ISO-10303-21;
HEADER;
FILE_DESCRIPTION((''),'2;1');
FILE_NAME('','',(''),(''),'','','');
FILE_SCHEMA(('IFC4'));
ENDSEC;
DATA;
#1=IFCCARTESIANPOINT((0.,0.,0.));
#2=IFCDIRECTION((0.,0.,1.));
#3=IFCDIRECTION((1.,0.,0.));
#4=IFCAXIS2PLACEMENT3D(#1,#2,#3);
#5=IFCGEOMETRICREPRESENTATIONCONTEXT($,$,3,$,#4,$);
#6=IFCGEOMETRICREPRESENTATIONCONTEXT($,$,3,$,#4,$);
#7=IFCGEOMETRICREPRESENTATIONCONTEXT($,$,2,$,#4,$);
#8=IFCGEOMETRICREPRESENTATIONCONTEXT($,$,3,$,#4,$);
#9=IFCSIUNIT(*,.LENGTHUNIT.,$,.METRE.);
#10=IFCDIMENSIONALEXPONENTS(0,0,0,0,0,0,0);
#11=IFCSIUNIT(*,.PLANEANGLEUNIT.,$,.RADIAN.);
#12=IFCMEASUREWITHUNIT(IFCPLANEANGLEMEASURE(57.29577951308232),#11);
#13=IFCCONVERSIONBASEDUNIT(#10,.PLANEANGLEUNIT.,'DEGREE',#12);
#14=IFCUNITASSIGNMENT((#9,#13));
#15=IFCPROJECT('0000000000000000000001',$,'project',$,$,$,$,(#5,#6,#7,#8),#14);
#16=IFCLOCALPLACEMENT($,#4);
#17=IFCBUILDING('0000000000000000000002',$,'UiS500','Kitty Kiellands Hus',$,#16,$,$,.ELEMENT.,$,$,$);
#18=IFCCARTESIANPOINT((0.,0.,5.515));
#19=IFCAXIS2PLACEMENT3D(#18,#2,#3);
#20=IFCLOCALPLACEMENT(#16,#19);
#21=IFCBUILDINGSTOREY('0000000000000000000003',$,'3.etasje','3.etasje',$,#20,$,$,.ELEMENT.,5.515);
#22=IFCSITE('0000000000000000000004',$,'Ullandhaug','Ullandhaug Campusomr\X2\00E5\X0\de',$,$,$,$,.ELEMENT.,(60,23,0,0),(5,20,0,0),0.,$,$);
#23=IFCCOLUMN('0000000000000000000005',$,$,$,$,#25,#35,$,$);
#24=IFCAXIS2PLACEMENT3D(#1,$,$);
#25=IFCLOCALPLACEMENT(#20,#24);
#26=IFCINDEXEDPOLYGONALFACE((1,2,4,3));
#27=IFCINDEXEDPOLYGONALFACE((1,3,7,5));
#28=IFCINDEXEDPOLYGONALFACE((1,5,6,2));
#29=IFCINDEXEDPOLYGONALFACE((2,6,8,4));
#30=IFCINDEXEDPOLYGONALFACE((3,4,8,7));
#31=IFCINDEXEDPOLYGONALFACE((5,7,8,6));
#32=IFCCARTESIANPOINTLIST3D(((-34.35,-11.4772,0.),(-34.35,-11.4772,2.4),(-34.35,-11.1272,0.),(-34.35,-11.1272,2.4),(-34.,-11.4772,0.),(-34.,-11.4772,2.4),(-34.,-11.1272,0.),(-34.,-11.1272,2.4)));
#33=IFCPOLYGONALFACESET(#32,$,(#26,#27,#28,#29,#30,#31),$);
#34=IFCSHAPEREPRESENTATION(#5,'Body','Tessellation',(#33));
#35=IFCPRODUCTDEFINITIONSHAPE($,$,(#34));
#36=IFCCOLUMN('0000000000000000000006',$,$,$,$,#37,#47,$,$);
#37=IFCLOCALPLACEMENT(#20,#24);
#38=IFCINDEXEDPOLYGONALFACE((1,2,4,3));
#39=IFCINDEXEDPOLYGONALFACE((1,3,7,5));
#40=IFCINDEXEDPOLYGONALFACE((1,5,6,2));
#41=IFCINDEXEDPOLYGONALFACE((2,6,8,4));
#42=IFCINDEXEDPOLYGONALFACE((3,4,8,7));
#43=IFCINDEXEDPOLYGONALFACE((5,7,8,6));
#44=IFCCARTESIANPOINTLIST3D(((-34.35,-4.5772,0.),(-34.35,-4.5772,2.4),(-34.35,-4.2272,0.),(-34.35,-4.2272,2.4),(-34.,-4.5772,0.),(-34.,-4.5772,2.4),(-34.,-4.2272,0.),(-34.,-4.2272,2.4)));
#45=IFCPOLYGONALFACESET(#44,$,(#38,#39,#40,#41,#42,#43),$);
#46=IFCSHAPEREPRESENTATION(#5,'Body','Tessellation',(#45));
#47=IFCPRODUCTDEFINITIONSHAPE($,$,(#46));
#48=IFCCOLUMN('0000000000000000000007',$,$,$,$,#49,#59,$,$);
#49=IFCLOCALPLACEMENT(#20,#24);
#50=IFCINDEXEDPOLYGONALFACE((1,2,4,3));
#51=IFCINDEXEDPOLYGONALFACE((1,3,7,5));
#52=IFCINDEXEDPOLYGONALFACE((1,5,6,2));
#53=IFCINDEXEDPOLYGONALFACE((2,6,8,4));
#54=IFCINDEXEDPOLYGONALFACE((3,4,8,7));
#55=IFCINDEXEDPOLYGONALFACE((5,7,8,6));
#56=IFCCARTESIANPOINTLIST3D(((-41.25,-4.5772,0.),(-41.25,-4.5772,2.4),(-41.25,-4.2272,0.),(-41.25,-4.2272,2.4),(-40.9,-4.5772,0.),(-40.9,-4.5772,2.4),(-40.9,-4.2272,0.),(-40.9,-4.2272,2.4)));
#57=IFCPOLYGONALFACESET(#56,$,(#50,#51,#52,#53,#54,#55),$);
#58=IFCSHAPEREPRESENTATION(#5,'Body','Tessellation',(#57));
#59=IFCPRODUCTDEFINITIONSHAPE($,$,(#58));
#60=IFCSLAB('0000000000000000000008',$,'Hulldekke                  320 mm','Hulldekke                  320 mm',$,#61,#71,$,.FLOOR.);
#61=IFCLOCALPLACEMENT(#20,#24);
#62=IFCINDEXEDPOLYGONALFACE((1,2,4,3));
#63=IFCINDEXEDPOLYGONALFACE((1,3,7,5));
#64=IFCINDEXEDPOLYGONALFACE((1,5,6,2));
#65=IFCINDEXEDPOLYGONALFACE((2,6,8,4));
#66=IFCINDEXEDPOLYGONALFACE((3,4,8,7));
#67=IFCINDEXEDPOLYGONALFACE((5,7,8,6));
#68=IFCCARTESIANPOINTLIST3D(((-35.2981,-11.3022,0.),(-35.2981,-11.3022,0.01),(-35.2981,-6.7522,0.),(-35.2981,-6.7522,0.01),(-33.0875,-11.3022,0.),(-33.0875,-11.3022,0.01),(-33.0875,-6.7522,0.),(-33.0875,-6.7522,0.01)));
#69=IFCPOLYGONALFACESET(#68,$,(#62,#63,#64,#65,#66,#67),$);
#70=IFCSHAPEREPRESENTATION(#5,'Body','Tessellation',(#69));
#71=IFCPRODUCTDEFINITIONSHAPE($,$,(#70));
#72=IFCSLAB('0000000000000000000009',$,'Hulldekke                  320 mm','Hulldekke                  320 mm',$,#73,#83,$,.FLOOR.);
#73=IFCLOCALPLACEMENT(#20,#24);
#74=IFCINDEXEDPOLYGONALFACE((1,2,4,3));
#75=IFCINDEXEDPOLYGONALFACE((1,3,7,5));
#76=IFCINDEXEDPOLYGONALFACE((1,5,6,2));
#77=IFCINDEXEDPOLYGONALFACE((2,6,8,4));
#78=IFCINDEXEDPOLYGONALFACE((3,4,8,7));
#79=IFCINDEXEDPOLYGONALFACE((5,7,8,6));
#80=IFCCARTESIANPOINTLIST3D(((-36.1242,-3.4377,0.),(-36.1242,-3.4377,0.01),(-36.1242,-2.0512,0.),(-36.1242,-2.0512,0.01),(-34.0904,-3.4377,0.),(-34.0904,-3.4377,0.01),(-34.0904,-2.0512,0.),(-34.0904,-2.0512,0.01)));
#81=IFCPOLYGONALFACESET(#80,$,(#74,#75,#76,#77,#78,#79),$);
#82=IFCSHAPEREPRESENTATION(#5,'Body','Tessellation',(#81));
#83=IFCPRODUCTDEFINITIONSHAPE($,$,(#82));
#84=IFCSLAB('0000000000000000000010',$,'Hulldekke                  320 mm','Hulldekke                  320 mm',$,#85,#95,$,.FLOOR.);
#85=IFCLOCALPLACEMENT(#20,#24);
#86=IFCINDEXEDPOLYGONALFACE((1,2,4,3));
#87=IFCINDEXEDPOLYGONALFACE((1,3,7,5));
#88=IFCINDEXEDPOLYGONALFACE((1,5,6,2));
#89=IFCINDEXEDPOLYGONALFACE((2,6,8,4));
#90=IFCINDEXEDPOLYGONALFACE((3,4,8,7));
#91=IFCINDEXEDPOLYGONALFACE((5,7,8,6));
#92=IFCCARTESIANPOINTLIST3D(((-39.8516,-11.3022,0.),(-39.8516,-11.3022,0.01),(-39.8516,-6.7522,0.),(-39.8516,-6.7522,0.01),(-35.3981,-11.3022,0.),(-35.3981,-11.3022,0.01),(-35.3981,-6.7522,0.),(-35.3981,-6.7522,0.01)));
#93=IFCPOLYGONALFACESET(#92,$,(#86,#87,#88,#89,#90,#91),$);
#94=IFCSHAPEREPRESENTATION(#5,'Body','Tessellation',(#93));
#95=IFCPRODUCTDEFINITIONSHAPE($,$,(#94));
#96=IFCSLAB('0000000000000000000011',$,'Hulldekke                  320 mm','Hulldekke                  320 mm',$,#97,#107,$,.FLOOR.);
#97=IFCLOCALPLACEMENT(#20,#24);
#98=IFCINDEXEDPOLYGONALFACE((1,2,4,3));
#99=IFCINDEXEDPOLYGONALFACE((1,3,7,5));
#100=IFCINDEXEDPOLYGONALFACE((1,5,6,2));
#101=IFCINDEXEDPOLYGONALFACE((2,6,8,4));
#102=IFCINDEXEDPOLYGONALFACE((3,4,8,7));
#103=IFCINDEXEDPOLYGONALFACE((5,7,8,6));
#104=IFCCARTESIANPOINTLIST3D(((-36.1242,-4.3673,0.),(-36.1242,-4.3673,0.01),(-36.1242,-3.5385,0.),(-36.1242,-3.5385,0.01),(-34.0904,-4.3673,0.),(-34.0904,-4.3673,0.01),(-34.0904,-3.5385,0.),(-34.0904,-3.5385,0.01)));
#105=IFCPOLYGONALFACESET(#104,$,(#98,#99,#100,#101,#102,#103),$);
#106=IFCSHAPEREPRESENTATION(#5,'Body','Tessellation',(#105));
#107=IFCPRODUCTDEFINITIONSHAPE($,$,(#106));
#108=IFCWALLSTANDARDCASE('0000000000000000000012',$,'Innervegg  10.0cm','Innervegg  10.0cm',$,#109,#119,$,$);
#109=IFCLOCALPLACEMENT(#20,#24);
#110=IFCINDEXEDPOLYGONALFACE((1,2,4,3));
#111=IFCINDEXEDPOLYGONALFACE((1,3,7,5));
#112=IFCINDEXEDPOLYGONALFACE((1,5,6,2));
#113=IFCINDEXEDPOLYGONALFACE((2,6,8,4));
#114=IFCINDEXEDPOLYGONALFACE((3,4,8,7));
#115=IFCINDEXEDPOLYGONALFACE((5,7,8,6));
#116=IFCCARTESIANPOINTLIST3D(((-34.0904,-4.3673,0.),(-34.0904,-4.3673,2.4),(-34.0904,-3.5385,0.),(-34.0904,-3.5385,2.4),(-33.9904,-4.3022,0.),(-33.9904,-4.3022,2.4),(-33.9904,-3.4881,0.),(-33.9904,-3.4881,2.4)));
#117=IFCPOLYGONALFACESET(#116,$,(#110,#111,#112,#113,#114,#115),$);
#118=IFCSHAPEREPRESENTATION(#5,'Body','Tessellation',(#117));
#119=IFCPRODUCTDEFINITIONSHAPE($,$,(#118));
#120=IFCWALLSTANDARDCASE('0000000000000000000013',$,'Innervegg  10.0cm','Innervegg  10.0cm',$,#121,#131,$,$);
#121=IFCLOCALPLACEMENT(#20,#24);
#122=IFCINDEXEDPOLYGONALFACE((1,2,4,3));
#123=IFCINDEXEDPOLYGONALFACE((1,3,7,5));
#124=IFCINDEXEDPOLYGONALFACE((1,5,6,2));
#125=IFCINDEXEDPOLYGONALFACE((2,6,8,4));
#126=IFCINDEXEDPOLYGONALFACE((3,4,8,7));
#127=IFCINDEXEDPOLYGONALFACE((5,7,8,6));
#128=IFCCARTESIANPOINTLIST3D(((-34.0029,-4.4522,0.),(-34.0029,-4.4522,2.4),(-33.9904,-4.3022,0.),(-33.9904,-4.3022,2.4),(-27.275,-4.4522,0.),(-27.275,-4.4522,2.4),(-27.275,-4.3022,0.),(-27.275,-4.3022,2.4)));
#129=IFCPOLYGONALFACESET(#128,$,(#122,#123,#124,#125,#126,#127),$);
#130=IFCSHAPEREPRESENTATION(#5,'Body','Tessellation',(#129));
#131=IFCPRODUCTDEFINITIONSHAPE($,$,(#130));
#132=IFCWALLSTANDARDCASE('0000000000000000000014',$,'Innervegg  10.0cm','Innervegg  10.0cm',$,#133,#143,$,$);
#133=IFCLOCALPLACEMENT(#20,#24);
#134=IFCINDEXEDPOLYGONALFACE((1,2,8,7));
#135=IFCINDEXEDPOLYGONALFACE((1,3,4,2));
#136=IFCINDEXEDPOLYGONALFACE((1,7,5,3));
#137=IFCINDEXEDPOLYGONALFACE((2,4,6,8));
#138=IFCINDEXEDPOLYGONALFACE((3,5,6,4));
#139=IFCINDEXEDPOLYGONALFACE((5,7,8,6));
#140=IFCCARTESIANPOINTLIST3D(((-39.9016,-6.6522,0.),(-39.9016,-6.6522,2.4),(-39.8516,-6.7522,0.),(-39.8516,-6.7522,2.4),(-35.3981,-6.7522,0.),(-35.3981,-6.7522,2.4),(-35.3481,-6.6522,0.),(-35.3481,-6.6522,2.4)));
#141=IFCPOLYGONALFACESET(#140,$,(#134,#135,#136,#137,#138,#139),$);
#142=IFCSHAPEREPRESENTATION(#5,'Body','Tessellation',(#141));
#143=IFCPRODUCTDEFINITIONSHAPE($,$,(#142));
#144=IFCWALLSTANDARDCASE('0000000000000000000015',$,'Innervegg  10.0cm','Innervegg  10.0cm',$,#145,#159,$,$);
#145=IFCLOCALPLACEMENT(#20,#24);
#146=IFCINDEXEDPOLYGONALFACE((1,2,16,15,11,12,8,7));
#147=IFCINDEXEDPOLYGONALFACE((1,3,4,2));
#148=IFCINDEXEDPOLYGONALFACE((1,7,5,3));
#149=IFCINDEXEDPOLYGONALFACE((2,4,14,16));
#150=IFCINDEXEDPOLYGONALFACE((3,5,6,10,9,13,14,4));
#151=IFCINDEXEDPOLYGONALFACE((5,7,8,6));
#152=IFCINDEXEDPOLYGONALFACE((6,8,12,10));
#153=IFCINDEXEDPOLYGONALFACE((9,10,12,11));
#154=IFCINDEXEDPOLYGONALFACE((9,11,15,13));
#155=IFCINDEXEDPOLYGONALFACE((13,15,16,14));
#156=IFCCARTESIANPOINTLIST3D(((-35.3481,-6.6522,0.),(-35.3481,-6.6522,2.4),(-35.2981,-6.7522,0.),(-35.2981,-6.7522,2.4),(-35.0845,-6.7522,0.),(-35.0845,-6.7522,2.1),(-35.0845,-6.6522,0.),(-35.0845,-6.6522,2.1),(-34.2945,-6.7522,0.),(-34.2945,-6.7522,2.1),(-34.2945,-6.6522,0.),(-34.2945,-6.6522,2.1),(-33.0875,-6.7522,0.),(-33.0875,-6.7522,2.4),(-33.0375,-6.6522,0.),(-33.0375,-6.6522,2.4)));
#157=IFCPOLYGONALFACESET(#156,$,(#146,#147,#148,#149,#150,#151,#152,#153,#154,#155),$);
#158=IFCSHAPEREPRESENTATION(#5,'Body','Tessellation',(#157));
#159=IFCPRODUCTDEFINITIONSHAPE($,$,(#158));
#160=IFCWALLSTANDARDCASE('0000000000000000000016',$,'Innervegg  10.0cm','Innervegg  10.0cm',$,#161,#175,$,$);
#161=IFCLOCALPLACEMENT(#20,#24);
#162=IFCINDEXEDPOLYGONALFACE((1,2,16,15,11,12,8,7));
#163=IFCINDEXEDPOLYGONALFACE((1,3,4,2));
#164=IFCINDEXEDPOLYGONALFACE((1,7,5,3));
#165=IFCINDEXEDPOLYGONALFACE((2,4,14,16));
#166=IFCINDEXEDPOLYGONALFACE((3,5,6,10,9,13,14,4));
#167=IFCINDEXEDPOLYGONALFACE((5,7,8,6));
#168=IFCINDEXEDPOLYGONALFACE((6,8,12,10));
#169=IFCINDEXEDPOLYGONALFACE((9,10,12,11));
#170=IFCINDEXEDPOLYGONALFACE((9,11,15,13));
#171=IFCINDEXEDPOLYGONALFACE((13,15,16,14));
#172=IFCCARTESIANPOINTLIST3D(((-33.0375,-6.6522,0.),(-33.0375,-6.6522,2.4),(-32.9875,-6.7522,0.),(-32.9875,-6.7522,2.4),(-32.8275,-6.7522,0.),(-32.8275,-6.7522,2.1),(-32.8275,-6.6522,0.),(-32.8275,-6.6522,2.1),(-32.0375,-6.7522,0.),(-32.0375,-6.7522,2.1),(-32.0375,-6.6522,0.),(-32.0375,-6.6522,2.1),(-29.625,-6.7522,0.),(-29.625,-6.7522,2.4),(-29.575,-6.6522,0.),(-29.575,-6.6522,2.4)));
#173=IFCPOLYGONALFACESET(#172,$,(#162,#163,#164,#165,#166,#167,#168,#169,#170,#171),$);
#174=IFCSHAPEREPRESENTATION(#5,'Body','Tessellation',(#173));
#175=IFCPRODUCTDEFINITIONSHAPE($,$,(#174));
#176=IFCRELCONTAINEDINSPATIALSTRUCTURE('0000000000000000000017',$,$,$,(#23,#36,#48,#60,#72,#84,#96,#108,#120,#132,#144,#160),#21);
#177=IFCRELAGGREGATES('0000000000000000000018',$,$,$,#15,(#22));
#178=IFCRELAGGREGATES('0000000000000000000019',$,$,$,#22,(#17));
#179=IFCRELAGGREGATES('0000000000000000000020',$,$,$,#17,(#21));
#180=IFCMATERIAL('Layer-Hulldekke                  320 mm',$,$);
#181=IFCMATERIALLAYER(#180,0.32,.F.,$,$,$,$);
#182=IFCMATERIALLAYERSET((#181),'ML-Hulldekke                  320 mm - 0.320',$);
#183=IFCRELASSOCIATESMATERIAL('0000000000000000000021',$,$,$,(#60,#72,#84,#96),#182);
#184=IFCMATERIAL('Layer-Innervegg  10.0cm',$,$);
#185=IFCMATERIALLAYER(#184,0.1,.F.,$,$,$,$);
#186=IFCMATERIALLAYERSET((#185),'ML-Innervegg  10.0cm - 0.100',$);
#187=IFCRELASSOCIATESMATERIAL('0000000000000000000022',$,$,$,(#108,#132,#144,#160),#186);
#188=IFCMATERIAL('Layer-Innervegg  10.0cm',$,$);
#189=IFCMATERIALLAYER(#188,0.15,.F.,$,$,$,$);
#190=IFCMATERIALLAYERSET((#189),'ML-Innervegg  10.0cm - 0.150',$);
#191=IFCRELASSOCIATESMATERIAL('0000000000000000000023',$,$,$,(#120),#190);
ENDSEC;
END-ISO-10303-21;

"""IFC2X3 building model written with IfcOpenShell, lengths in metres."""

from ifc_helpers import new_model, entity, si_unit, converted_unit, frame, origin_with_axes, origin_2d_with_axis, place, context, project, spatial, polyline, rectangle, outline, extrude, material, layer, layer_set, layer_usage, element, save


model = new_model("IFC2X3")

# Units and contexts
context_of_model_1 = context(None, 3, world=origin_with_axes())
context_of_model_2 = context(None, 3, world=origin_with_axes())
context_of_model_3 = context(None, 2, world=origin_with_axes())
context_of_model_4 = context(None, 3, world=origin_with_axes())
ifc_project = project(units=[si_unit("LENGTHUNIT", "METRE"), converted_unit("PLANEANGLEUNIT", "DEGREE", entity("IfcPlaneAngleMeasure", 57.29577951308232), si_unit("PLANEANGLEUNIT", "RADIAN"), dimensions=[0, 0, 0, 0, 0, 0, 0])], contexts=[context_of_model_1, context_of_model_2, context_of_model_3, context_of_model_4])

# Site, building, storey
site = spatial("IfcSite", under=ifc_project, Name="Ullandhaug", Description="Ullandhaug Campusområde", CompositionType="ELEMENT", RefLatitude=(60, 23, 0, 0), RefLongitude=(5, 20, 0, 0), RefElevation=0.0)
building_placement = place(None, origin_with_axes())
building = spatial("IfcBuilding", under=site, at=building_placement, Name="UiS500", Description="Kitty Kiellands Hus", CompositionType="ELEMENT")
storey_placement = place(building_placement, frame((0.0, 0.0, 5.515), z_axis=(0.0, 0.0, 1.0), x_axis=(1.0, 0.0, 0.0)))
storey = spatial("IfcBuildingStorey", under=building, at=storey_placement, Name="3.etasje", Description="3.etasje", CompositionType="ELEMENT", Elevation=5.515)

# Columns
for number, where, z_axis, x_axis in (
    (1, (-34.175, -11.3022, 0.0), (0.0, 0.0, 1.0), (1.0, 0.0, 0.0)),
    (2, (-34.175, -4.4022, 0.0), (0.0, 0.0, 1.0), (1.0, 0.0, 0.0)),
    (3, (-41.075, -4.4022, 0.0), (0.0, 0.0, 1.0), (1.0, 0.0, 0.0)),
):
    element("IfcColumn", number, at=place(storey_placement, frame(where, z_axis=z_axis, x_axis=x_axis)), inside=storey, context=context_of_model_1, shape_type="SweptSolid", body=[
        extrude(rectangle(XDim=0.35, YDim=0.35, at=origin_2d_with_axis()), origin_with_axes(), (0.0, 0.0, 1.0), 2.4),
    ])

# Slabs
ifc_material_1 = material(Name="Layer-Hulldekke                  320 mm")
ifc_layer_1 = layer(ifc_material_1, 0.32, ventilated=False)
ifc_layer_set_1 = layer_set([ifc_layer_1], Name="ML-Hulldekke                  320 mm - 0.320")
ifc_layer_usage_1 = layer_usage(ifc_layer_set_1, "AXIS2", "POSITIVE", 0.0)
slab_1_placement = place(storey_placement, frame((-35.2981, -11.3022, 0.0), z_axis=(0.0, 0.0, 1.0), x_axis=(1.0, 0.0, 0.0)))
element("IfcSlab", 4, at=slab_1_placement, inside=storey, material=ifc_layer_usage_1, Name="Hulldekke                  320 mm", Description="Hulldekke                  320 mm", PredefinedType="FLOOR", context=context_of_model_1, shape_type="SweptSolid", body=[
    extrude(outline(polyline([(0.0, 0.0), (2.2106, 0.0), (2.2106, 4.55), (0.0, 4.55), (0.0, 0.0)])), origin_with_axes(), (0.0, 0.0, 1.0), 0.01),
])
slab_2_placement = place(storey_placement, frame((-36.1242, -3.4377, 0.0), z_axis=(0.0, 0.0, 1.0), x_axis=(1.0, 0.0, 0.0)))
element("IfcSlab", 5, at=slab_2_placement, inside=storey, material=ifc_layer_usage_1, Name="Hulldekke                  320 mm", Description="Hulldekke                  320 mm", PredefinedType="FLOOR", context=context_of_model_1, shape_type="SweptSolid", body=[
    extrude(outline(polyline([(0.0, 0.0), (2.0338, 0.0), (2.0338, 1.3864), (0.0, 1.3864), (0.0, 0.0)])), origin_with_axes(), (0.0, 0.0, 1.0), 0.01),
])
slab_3_placement = place(storey_placement, frame((-39.8516, -6.7522, 0.0), z_axis=(0.0, 0.0, 1.0), x_axis=(1.0, 0.0, 0.0)))
element("IfcSlab", 6, at=slab_3_placement, inside=storey, material=ifc_layer_usage_1, Name="Hulldekke                  320 mm", Description="Hulldekke                  320 mm", PredefinedType="FLOOR", context=context_of_model_1, shape_type="SweptSolid", body=[
    extrude(outline(polyline([(0.0, 0.0), (4.55, 0.0), (4.55, 4.4535), (0.0, 4.4535), (0.0, 0.0)])), frame((0.0, 0.0, 0.0), z_axis=(0.0, 0.0, 1.0), x_axis=(0.0, -1.0, 0.0)), (0.0, 0.0, 1.0), 0.01),
])
slab_4_placement = place(storey_placement, frame((-36.1242, -4.3673, 0.0), z_axis=(0.0, 0.0, 1.0), x_axis=(1.0, 0.0, 0.0)))
element("IfcSlab", 7, at=slab_4_placement, inside=storey, material=ifc_layer_usage_1, Name="Hulldekke                  320 mm", Description="Hulldekke                  320 mm", PredefinedType="FLOOR", context=context_of_model_1, shape_type="SweptSolid", body=[
    extrude(outline(polyline([(0.0, 0.0), (2.0338, 0.0), (2.0338, 0.8288), (0.0, 0.8288), (0.0, 0.0)])), origin_with_axes(), (0.0, 0.0, 1.0), 0.01),
])

# Walls
ifc_material_2 = material(Name="Layer-Innervegg  10.0cm")
ifc_layer_2 = layer(ifc_material_2, 0.1, ventilated=False)
ifc_layer_set_2 = layer_set([ifc_layer_2], Name="ML-Innervegg  10.0cm - 0.100")
ifc_layer_usage_2 = layer_usage(ifc_layer_set_2, "AXIS2", "POSITIVE", 0.0)
wall_1_placement = place(storey_placement, frame((-34.0904, -3.5385, 0.0), z_axis=(0.0, 0.0, 1.0), x_axis=(0.0, -1.0, 0.0)))
element("IfcWallStandardCase", 8, at=wall_1_placement, inside=storey, material=ifc_layer_usage_2, Name="Innervegg  10.0cm", Description="Innervegg  10.0cm", context=context_of_model_1, shape_type="SweptSolid", body=[
    extrude(outline(polyline([(0.0, 0.0), (0.8288, 0.0), (0.7638, 0.1), (-0.0504, 0.1), (0.0, 0.0)])), frame((0.0, 0.0, 0.0), z_axis=(0.0, 0.0, 1.0), x_axis=(1.0, 0.0, 0.0)), (0.0, 0.0, 1.0), 2.4),
])
ifc_material_3 = material(Name="Layer-Innervegg  10.0cm")
ifc_layer_3 = layer(ifc_material_3, 0.15, ventilated=False)
ifc_layer_set_3 = layer_set([ifc_layer_3], Name="ML-Innervegg  10.0cm - 0.150")
ifc_layer_usage_3 = layer_usage(ifc_layer_set_3, "AXIS2", "POSITIVE", 0.0)
wall_2_placement = place(storey_placement, frame((-34.0029, -4.4522, 0.0), z_axis=(0.0, 0.0, 1.0), x_axis=(1.0, 0.0, 0.0)))
element("IfcWallStandardCase", 9, at=wall_2_placement, inside=storey, material=ifc_layer_usage_3, Name="Innervegg  10.0cm", Description="Innervegg  10.0cm", context=context_of_model_1, shape_type="SweptSolid", body=[
    extrude(outline(polyline([(0.0, 0.0), (6.7279, 0.0), (6.7279, 0.15), (0.0125, 0.15), (0.0, 0.0)])), origin_with_axes(), (0.0, 0.0, 1.0), 2.4),
])
wall_3_placement = place(storey_placement, frame((-39.8516, -6.7522, 0.0), z_axis=(0.0, 0.0, 1.0), x_axis=(1.0, 0.0, 0.0)))
element("IfcWallStandardCase", 10, at=wall_3_placement, inside=storey, material=ifc_layer_usage_2, Name="Innervegg  10.0cm", Description="Innervegg  10.0cm", context=context_of_model_1, shape_type="SweptSolid", body=[
    extrude(outline(polyline([(0.0, 0.0), (4.4535, 0.0), (4.5035, 0.1), (-0.05, 0.1), (0.0, 0.0)])), origin_with_axes(), (0.0, 0.0, 1.0), 2.4),
])

# Walls, openings
wall_4_placement = place(storey_placement, frame((-35.2981, -6.7522, 0.0), z_axis=(0.0, 0.0, 1.0), x_axis=(1.0, 0.0, 0.0)))
wall_4 = element("IfcWallStandardCase", 11, at=wall_4_placement, inside=storey, material=ifc_layer_usage_2, Name="Innervegg  10.0cm", Description="Innervegg  10.0cm", context=context_of_model_1, shape_type="SweptSolid", body=[
    extrude(outline(polyline([(0.0, 0.0), (2.2106, 0.0), (2.2606, 0.1), (-0.05, 0.1), (0.0, 0.0)])), origin_with_axes(), (0.0, 0.0, 1.0), 2.4),
])
opening_1_placement = place(wall_4_placement, frame((0.2137, 0.1, 0.0), z_axis=(0.0, 0.0, 1.0), x_axis=(1.0, 0.0, 0.0)))
element("IfcOpeningElement", 12, at=opening_1_placement, cuts=wall_4, context=context_of_model_1, shape_type="SweptSolid", body=[
    extrude(outline(polyline([(0.0, 0.0), (2.1, 0.0), (2.1, 0.79), (0.0, 0.79), (0.0, 0.0)])), frame((0.0, 0.0, 0.0), z_axis=(0.0, 1.0, 0.0), x_axis=(0.0, 0.0, 1.0)), (0.0, 0.0, -1.0), 0.1),
])
wall_5_placement = place(storey_placement, frame((-32.9875, -6.7522, 0.0), z_axis=(0.0, 0.0, 1.0), x_axis=(1.0, 0.0, 0.0)))
wall_5 = element("IfcWallStandardCase", 13, at=wall_5_placement, inside=storey, material=ifc_layer_usage_2, Name="Innervegg  10.0cm", Description="Innervegg  10.0cm", context=context_of_model_1, shape_type="SweptSolid", body=[
    extrude(outline(polyline([(0.0, 0.0), (3.3625, 0.0), (3.4125, 0.1), (-0.05, 0.1), (0.0, 0.0)])), origin_with_axes(), (0.0, 0.0, 1.0), 2.4),
])
opening_2_placement = place(wall_5_placement, frame((0.16, 0.1, 0.0), z_axis=(0.0, 0.0, 1.0), x_axis=(1.0, 0.0, 0.0)))
element("IfcOpeningElement", 14, at=opening_2_placement, cuts=wall_5, context=context_of_model_1, shape_type="SweptSolid", body=[
    extrude(outline(polyline([(0.0, 0.0), (2.1, 0.0), (2.1, 0.79), (0.0, 0.79), (0.0, 0.0)])), frame((0.0, 0.0, 0.0), z_axis=(0.0, 1.0, 0.0), x_axis=(0.0, 0.0, 1.0)), (0.0, 0.0, -1.0), 0.1),
])

save(model, "model.ifc")
